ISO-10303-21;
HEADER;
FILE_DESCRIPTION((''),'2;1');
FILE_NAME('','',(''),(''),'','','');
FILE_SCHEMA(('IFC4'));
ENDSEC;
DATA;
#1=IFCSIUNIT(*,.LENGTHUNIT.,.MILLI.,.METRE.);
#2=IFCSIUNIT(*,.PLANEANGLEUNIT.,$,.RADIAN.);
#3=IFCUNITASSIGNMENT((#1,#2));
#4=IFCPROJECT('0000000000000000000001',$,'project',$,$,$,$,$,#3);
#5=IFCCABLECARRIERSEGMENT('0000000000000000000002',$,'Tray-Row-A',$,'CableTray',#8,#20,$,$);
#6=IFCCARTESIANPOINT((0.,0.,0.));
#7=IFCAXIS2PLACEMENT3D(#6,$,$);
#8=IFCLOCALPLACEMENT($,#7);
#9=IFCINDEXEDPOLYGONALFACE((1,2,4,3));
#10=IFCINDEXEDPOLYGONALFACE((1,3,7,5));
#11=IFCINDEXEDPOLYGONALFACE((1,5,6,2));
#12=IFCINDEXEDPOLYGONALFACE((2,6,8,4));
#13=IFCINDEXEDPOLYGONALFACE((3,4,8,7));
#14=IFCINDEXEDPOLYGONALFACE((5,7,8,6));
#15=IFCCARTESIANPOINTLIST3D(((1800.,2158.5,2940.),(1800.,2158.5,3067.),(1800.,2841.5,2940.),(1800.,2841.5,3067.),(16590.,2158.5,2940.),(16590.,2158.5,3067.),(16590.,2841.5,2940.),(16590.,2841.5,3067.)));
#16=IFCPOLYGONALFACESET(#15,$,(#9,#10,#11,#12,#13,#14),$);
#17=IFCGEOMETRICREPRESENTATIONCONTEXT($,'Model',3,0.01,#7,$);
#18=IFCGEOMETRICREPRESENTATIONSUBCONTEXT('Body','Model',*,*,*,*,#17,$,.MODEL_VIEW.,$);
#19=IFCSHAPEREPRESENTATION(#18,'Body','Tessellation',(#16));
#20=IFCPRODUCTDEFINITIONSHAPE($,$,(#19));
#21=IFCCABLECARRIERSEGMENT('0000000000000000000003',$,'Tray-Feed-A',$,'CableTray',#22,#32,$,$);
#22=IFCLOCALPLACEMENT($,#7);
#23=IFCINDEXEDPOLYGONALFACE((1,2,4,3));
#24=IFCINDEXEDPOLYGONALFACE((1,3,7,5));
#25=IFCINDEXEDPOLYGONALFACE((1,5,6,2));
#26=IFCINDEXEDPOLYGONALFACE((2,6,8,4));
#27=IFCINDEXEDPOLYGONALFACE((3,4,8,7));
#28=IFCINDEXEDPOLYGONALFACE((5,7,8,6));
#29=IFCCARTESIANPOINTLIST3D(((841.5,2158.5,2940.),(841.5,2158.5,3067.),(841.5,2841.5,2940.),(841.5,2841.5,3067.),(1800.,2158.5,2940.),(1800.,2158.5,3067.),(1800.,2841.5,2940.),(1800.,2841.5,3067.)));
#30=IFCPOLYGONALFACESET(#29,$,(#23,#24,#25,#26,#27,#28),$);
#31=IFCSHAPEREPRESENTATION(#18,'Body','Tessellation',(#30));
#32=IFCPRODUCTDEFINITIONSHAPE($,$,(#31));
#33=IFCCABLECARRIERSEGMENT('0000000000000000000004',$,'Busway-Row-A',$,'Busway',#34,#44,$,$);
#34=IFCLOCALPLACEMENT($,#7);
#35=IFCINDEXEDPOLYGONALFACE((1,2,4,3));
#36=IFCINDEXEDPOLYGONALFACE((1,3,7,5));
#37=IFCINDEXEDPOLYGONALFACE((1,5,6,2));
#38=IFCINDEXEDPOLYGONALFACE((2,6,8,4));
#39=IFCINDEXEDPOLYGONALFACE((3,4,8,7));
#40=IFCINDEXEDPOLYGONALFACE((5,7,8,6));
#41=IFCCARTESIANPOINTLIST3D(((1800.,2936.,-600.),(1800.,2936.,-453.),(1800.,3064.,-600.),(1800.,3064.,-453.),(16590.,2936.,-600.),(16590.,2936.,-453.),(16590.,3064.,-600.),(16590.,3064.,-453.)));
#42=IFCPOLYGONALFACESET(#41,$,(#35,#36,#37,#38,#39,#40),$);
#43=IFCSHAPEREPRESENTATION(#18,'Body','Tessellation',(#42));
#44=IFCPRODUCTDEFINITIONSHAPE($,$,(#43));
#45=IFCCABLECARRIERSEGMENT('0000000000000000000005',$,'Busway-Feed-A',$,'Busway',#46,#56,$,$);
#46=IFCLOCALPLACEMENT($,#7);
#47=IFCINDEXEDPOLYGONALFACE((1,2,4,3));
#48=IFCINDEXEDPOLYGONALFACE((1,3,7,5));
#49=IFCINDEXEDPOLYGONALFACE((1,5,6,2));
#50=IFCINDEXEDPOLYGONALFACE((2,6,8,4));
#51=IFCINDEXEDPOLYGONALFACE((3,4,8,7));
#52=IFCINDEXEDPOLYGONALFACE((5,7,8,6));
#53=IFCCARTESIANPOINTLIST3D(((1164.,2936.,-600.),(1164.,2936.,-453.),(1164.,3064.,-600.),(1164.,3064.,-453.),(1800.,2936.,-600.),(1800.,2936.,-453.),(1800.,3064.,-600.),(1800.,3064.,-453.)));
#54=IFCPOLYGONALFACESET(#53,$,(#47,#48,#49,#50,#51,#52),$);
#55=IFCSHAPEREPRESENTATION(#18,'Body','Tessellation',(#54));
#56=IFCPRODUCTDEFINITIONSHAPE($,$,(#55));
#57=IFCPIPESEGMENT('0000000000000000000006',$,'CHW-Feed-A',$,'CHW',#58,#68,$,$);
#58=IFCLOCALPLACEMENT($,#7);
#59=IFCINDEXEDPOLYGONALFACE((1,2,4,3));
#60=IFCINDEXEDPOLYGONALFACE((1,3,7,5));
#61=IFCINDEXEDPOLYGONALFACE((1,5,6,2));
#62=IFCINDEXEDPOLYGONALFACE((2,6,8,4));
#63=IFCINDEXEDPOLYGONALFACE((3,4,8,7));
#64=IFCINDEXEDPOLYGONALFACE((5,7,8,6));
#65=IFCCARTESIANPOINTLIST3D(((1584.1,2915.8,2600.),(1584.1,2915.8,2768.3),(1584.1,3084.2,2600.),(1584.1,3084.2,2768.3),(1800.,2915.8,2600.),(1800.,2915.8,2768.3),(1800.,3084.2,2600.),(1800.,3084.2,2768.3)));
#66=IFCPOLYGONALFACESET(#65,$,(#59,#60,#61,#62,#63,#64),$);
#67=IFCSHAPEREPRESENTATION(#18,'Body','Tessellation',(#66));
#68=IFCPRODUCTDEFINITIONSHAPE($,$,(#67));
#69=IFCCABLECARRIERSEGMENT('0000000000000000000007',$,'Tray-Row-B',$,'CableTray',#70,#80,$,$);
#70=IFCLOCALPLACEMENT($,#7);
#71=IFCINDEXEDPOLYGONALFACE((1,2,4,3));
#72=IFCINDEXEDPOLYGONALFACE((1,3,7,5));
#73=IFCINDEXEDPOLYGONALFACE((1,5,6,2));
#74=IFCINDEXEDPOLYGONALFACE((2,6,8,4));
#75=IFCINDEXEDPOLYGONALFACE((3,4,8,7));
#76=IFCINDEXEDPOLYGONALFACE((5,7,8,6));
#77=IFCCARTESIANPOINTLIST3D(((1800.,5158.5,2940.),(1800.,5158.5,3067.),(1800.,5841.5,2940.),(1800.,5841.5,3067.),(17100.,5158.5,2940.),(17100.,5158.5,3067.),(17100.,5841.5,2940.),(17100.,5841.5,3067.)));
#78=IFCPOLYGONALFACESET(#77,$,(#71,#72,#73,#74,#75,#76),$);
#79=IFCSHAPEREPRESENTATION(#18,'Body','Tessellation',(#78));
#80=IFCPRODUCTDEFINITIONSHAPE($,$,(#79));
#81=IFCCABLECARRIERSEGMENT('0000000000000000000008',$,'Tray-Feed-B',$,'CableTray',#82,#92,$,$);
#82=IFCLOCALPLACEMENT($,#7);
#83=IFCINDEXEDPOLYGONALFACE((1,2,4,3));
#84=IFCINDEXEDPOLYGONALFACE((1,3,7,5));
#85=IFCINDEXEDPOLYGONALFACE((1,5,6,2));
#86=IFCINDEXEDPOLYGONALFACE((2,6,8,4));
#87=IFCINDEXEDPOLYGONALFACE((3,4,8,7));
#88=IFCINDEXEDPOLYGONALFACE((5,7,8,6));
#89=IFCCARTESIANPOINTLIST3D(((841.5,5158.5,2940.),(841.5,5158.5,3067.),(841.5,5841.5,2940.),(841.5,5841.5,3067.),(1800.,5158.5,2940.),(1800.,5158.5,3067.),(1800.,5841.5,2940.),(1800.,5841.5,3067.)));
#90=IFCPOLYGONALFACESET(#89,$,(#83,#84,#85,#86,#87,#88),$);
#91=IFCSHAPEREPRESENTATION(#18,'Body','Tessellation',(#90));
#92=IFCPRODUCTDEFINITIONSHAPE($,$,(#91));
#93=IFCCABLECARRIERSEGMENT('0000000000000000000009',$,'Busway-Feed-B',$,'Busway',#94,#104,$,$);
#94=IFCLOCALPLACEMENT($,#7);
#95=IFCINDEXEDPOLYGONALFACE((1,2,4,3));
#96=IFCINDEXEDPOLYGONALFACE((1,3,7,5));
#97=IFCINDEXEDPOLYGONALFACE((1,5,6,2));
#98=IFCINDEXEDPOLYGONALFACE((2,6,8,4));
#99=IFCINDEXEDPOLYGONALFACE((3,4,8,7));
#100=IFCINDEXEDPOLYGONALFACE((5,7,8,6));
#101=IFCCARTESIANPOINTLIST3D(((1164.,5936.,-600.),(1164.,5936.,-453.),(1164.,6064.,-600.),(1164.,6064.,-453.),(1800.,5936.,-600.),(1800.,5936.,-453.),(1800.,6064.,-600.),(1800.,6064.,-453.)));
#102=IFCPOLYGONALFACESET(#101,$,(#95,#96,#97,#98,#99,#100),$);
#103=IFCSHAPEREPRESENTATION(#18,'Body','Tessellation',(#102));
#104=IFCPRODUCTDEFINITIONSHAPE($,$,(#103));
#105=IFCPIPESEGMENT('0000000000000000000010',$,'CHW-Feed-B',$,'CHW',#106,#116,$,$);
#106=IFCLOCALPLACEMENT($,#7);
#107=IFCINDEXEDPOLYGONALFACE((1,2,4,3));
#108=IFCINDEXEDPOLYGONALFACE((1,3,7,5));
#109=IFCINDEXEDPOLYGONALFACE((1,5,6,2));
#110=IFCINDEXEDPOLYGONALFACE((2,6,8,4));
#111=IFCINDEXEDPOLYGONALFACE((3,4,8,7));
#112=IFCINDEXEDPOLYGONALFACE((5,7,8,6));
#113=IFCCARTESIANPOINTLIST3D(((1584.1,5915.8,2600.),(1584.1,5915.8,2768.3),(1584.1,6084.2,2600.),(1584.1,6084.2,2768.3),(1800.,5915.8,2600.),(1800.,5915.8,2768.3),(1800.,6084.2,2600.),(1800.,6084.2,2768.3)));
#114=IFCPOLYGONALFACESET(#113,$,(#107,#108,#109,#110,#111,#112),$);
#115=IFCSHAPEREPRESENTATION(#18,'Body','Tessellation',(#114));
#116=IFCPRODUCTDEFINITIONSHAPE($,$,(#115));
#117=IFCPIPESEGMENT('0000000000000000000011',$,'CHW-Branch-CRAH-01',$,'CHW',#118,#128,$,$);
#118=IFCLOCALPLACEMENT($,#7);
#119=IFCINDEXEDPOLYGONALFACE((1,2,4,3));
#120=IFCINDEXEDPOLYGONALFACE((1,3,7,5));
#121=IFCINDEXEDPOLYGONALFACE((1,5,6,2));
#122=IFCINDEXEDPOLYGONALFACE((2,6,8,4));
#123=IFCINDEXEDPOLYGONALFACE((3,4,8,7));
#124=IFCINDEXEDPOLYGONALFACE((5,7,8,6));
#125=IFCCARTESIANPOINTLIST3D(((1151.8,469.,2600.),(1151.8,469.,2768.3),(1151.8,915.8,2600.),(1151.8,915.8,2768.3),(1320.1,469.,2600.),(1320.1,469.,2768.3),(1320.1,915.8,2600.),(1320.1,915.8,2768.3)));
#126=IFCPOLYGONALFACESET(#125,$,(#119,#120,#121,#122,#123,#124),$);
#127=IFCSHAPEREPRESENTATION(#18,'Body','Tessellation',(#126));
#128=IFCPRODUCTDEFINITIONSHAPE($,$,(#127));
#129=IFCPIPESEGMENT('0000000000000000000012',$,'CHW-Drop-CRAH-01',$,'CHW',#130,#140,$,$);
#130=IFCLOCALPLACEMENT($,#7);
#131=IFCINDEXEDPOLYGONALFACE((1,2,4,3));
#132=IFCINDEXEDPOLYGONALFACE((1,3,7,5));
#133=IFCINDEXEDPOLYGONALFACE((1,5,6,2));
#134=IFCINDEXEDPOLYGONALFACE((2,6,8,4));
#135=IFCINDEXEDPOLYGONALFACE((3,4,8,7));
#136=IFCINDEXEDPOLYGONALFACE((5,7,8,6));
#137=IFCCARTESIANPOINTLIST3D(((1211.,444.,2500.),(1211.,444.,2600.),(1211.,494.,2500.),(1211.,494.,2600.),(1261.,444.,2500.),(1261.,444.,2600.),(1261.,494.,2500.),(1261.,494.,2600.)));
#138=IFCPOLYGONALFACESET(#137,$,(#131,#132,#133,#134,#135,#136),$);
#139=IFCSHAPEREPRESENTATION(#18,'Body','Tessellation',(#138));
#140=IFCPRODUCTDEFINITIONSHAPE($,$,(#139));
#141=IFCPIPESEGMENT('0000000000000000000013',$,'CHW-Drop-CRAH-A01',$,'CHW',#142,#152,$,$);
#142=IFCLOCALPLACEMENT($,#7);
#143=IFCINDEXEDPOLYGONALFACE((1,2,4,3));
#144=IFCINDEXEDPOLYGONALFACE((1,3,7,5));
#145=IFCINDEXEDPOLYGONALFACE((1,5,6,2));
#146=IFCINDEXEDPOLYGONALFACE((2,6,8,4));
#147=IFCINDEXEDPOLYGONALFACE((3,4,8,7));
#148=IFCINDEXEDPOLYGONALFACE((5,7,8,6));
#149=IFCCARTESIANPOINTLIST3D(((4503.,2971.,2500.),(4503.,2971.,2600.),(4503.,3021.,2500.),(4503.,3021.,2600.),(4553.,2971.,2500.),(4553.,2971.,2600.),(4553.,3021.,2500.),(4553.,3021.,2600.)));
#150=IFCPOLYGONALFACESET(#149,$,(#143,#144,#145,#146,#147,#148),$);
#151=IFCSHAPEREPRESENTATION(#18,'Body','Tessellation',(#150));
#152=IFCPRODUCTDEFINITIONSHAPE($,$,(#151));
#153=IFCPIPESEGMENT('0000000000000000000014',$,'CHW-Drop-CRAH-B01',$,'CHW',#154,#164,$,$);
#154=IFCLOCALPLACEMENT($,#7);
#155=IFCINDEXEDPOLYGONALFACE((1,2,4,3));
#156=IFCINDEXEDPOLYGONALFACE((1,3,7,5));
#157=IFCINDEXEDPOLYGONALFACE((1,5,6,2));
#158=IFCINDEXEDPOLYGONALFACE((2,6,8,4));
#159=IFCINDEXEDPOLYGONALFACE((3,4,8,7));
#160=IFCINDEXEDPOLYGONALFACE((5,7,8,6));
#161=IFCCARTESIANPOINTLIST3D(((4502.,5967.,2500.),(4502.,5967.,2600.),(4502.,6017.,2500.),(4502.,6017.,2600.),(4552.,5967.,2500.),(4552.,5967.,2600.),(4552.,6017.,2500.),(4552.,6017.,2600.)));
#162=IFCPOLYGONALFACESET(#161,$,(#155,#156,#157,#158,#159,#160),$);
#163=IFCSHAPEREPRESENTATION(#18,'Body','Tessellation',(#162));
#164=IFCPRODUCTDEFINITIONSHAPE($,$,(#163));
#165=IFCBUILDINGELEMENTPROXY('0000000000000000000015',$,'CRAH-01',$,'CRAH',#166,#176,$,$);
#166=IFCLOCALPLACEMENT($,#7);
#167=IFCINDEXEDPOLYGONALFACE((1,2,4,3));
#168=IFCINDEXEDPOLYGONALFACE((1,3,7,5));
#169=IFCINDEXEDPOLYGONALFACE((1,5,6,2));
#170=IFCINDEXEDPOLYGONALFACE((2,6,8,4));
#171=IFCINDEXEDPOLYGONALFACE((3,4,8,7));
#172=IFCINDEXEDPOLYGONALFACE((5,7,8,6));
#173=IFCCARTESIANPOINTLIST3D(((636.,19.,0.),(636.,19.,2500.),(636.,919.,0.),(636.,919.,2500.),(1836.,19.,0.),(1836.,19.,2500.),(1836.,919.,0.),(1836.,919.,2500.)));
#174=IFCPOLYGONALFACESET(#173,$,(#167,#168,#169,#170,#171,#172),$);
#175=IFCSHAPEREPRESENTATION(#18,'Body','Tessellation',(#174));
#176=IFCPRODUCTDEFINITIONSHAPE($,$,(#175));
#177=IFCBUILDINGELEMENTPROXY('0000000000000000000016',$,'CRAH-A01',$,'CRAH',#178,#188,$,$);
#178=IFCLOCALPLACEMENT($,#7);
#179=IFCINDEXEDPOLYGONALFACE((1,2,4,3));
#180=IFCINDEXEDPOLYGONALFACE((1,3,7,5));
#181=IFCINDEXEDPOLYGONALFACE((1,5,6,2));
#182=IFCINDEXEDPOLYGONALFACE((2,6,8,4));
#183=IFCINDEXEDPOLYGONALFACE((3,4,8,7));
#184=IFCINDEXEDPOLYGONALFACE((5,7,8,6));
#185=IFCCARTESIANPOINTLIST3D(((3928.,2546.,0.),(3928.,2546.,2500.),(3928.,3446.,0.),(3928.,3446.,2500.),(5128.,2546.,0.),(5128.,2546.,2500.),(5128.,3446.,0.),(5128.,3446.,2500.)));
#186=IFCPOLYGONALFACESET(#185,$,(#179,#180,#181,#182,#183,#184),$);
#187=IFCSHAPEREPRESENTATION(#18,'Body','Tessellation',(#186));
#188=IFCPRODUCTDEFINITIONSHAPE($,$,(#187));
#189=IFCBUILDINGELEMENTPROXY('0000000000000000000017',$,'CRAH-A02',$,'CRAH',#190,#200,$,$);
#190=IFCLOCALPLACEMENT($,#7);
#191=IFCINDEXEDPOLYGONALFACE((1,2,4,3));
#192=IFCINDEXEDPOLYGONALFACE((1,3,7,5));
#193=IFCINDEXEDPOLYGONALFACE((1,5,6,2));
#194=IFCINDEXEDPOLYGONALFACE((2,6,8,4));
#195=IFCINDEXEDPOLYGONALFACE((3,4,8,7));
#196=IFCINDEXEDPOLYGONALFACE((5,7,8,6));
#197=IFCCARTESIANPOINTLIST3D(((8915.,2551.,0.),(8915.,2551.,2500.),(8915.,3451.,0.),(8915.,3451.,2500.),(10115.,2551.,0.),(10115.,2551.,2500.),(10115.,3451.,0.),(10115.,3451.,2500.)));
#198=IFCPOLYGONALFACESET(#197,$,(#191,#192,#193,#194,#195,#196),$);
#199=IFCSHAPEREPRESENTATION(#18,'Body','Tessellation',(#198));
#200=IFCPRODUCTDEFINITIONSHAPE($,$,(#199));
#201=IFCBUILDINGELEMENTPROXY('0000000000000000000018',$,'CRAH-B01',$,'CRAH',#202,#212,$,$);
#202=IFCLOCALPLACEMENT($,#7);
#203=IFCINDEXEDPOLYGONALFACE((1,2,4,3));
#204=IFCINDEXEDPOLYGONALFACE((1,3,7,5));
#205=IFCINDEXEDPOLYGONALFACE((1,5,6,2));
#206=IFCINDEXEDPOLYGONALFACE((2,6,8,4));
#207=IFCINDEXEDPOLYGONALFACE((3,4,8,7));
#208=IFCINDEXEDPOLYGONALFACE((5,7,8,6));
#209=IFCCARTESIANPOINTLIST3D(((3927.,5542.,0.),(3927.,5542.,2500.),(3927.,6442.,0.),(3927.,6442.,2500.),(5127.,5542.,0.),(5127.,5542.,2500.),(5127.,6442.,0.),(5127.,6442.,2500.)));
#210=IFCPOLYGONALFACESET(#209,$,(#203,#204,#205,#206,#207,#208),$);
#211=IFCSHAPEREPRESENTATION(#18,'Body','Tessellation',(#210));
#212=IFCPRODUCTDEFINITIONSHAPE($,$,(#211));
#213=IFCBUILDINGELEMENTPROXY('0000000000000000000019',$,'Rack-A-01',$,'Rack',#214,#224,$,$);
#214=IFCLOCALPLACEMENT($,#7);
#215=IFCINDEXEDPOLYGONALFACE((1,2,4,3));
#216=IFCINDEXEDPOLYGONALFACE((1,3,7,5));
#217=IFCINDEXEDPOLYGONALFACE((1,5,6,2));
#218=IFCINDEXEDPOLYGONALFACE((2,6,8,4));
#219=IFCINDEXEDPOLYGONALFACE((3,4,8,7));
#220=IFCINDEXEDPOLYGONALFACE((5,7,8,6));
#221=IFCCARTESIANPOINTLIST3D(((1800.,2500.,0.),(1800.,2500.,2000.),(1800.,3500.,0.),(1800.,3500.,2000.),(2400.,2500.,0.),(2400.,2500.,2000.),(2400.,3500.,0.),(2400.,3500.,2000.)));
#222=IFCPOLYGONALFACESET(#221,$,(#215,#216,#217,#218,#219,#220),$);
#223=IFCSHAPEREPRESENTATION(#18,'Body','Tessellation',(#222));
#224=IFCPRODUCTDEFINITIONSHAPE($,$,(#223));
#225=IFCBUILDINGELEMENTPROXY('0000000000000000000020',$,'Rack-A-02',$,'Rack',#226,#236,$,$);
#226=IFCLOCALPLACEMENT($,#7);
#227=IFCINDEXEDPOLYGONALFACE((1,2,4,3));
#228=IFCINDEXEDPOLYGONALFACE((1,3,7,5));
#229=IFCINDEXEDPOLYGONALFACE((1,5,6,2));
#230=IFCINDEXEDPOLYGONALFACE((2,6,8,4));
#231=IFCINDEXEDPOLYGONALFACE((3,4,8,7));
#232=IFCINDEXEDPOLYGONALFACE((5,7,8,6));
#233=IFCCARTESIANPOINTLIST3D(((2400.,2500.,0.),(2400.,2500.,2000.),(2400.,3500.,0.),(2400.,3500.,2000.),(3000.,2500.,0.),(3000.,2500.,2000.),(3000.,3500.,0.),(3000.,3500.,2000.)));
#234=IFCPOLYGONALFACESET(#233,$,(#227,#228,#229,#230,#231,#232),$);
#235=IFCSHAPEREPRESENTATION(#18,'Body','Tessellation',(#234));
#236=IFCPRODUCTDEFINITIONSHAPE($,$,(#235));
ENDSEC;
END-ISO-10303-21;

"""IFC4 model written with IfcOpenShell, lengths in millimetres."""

from ifc_helpers import new_model, si_unit, frame, origin, place, context, subcontext, project, rectangle, extrude, element, save


model = new_model("IFC4")

# Units and contexts
model_context = context("Model", 3, precision=0.01, world=origin())
body_context = subcontext(model_context, "Body", "Model", "MODEL_VIEW")
ifc_project = project(units=[si_unit("LENGTHUNIT", "METRE", prefix="MILLI"), si_unit("PLANEANGLEUNIT", "RADIAN")])

# Cable carrier segments
placement = place(None, origin())
cable_carrier_segment_1_placement = place(placement, frame((9195.0, 2500.0, 2940.0)))
element("IfcCableCarrierSegment", 1, at=cable_carrier_segment_1_placement, Name="Tray-Row-A", ObjectType="CableTray", context=body_context, shape_type="SweptSolid", body=[
    extrude(rectangle(XDim=14790.0, YDim=683.0), origin(), (0.0, 0.0, 1.0), 127.0),
])
cable_carrier_segment_2_placement = place(placement, frame((1320.8, 2500.0, 2940.0)))
element("IfcCableCarrierSegment", 2, at=cable_carrier_segment_2_placement, Name="Tray-Feed-A", ObjectType="CableTray", context=body_context, shape_type="SweptSolid", body=[
    extrude(rectangle(XDim=958.5, YDim=683.0), origin(), (0.0, 0.0, 1.0), 127.0),
])
cable_carrier_segment_3_placement = place(placement, frame((9195.0, 3000.0, -600.0)))
element("IfcCableCarrierSegment", 3, at=cable_carrier_segment_3_placement, Name="Busway-Row-A", ObjectType="Busway", context=body_context, shape_type="SweptSolid", body=[
    extrude(rectangle(XDim=14790.0, YDim=128.0), origin(), (0.0, 0.0, 1.0), 147.0),
])
cable_carrier_segment_4_placement = place(placement, frame((1482.0, 3000.0, -600.0)))
element("IfcCableCarrierSegment", 4, at=cable_carrier_segment_4_placement, Name="Busway-Feed-A", ObjectType="Busway", context=body_context, shape_type="SweptSolid", body=[
    extrude(rectangle(XDim=636.0, YDim=128.0), origin(), (0.0, 0.0, 1.0), 147.0),
])

# Pipe segment
pipe_segment_1_placement = place(placement, frame((1692.1, 3000.0, 2600.0)))
element("IfcPipeSegment", 5, at=pipe_segment_1_placement, Name="CHW-Feed-A", ObjectType="CHW", context=body_context, shape_type="SweptSolid", body=[
    extrude(rectangle(XDim=215.8, YDim=168.3), origin(), (0.0, 0.0, 1.0), 168.3),
])

# Cable carrier segments
cable_carrier_segment_5_placement = place(placement, frame((9450.0, 5500.0, 2940.0)))
element("IfcCableCarrierSegment", 6, at=cable_carrier_segment_5_placement, Name="Tray-Row-B", ObjectType="CableTray", context=body_context, shape_type="SweptSolid", body=[
    extrude(rectangle(XDim=15300.0, YDim=683.0), origin(), (0.0, 0.0, 1.0), 127.0),
])
cable_carrier_segment_6_placement = place(placement, frame((1320.8, 5500.0, 2940.0)))
element("IfcCableCarrierSegment", 7, at=cable_carrier_segment_6_placement, Name="Tray-Feed-B", ObjectType="CableTray", context=body_context, shape_type="SweptSolid", body=[
    extrude(rectangle(XDim=958.5, YDim=683.0), origin(), (0.0, 0.0, 1.0), 127.0),
])
cable_carrier_segment_7_placement = place(placement, frame((1482.0, 6000.0, -600.0)))
element("IfcCableCarrierSegment", 8, at=cable_carrier_segment_7_placement, Name="Busway-Feed-B", ObjectType="Busway", context=body_context, shape_type="SweptSolid", body=[
    extrude(rectangle(XDim=636.0, YDim=128.0), origin(), (0.0, 0.0, 1.0), 147.0),
])

# Pipe segments
pipe_segment_2_placement = place(placement, frame((1692.1, 6000.0, 2600.0)))
element("IfcPipeSegment", 9, at=pipe_segment_2_placement, Name="CHW-Feed-B", ObjectType="CHW", context=body_context, shape_type="SweptSolid", body=[
    extrude(rectangle(XDim=215.8, YDim=168.3), origin(), (0.0, 0.0, 1.0), 168.3),
])
pipe_segment_3_placement = place(placement, frame((1236.0, 692.4, 2600.0)))
element("IfcPipeSegment", 10, at=pipe_segment_3_placement, Name="CHW-Branch-CRAH-01", ObjectType="CHW", context=body_context, shape_type="SweptSolid", body=[
    extrude(rectangle(XDim=168.3, YDim=446.9), origin(), (0.0, 0.0, 1.0), 168.3),
])
for number, where, name in (
    (11, (1236.0, 469.0, 2500.0), "CHW-Drop-CRAH-01"),
    (12, (4528.0, 2996.0, 2500.0), "CHW-Drop-CRAH-A01"),
    (13, (4527.0, 5992.0, 2500.0), "CHW-Drop-CRAH-B01"),
):
    element("IfcPipeSegment", number, at=place(placement, frame(where)), Name=name, ObjectType="CHW", context=body_context, shape_type="SweptSolid", body=[
        extrude(rectangle(XDim=50.0, YDim=50.0), origin(), (0.0, 0.0, 1.0), 100.0),
    ])

# Building element proxies
for number, where, name in (
    (14, (1236.0, 469.0, 0.0), "CRAH-01"),
    (15, (4528.0, 2996.0, 0.0), "CRAH-A01"),
    (16, (9515.0, 3001.0, 0.0), "CRAH-A02"),
    (17, (4527.0, 5992.0, 0.0), "CRAH-B01"),
):
    element("IfcBuildingElementProxy", number, at=place(placement, frame(where)), Name=name, ObjectType="CRAH", context=body_context, shape_type="SweptSolid", body=[
        extrude(rectangle(XDim=1200.0, YDim=900.0), origin(), (0.0, 0.0, 1.0), 2500.0),
    ])
for number, where, name in (
    (18, (2100.0, 3000.0, 0.0), "Rack-A-01"),
    (19, (2700.0, 3000.0, 0.0), "Rack-A-02"),
):
    element("IfcBuildingElementProxy", number, at=place(placement, frame(where)), Name=name, ObjectType="Rack", context=body_context, shape_type="SweptSolid", body=[
        extrude(rectangle(XDim=600.0, YDim=1000.0), origin(), (0.0, 0.0, 1.0), 2000.0),
    ])

save(model, "model.ifc")
